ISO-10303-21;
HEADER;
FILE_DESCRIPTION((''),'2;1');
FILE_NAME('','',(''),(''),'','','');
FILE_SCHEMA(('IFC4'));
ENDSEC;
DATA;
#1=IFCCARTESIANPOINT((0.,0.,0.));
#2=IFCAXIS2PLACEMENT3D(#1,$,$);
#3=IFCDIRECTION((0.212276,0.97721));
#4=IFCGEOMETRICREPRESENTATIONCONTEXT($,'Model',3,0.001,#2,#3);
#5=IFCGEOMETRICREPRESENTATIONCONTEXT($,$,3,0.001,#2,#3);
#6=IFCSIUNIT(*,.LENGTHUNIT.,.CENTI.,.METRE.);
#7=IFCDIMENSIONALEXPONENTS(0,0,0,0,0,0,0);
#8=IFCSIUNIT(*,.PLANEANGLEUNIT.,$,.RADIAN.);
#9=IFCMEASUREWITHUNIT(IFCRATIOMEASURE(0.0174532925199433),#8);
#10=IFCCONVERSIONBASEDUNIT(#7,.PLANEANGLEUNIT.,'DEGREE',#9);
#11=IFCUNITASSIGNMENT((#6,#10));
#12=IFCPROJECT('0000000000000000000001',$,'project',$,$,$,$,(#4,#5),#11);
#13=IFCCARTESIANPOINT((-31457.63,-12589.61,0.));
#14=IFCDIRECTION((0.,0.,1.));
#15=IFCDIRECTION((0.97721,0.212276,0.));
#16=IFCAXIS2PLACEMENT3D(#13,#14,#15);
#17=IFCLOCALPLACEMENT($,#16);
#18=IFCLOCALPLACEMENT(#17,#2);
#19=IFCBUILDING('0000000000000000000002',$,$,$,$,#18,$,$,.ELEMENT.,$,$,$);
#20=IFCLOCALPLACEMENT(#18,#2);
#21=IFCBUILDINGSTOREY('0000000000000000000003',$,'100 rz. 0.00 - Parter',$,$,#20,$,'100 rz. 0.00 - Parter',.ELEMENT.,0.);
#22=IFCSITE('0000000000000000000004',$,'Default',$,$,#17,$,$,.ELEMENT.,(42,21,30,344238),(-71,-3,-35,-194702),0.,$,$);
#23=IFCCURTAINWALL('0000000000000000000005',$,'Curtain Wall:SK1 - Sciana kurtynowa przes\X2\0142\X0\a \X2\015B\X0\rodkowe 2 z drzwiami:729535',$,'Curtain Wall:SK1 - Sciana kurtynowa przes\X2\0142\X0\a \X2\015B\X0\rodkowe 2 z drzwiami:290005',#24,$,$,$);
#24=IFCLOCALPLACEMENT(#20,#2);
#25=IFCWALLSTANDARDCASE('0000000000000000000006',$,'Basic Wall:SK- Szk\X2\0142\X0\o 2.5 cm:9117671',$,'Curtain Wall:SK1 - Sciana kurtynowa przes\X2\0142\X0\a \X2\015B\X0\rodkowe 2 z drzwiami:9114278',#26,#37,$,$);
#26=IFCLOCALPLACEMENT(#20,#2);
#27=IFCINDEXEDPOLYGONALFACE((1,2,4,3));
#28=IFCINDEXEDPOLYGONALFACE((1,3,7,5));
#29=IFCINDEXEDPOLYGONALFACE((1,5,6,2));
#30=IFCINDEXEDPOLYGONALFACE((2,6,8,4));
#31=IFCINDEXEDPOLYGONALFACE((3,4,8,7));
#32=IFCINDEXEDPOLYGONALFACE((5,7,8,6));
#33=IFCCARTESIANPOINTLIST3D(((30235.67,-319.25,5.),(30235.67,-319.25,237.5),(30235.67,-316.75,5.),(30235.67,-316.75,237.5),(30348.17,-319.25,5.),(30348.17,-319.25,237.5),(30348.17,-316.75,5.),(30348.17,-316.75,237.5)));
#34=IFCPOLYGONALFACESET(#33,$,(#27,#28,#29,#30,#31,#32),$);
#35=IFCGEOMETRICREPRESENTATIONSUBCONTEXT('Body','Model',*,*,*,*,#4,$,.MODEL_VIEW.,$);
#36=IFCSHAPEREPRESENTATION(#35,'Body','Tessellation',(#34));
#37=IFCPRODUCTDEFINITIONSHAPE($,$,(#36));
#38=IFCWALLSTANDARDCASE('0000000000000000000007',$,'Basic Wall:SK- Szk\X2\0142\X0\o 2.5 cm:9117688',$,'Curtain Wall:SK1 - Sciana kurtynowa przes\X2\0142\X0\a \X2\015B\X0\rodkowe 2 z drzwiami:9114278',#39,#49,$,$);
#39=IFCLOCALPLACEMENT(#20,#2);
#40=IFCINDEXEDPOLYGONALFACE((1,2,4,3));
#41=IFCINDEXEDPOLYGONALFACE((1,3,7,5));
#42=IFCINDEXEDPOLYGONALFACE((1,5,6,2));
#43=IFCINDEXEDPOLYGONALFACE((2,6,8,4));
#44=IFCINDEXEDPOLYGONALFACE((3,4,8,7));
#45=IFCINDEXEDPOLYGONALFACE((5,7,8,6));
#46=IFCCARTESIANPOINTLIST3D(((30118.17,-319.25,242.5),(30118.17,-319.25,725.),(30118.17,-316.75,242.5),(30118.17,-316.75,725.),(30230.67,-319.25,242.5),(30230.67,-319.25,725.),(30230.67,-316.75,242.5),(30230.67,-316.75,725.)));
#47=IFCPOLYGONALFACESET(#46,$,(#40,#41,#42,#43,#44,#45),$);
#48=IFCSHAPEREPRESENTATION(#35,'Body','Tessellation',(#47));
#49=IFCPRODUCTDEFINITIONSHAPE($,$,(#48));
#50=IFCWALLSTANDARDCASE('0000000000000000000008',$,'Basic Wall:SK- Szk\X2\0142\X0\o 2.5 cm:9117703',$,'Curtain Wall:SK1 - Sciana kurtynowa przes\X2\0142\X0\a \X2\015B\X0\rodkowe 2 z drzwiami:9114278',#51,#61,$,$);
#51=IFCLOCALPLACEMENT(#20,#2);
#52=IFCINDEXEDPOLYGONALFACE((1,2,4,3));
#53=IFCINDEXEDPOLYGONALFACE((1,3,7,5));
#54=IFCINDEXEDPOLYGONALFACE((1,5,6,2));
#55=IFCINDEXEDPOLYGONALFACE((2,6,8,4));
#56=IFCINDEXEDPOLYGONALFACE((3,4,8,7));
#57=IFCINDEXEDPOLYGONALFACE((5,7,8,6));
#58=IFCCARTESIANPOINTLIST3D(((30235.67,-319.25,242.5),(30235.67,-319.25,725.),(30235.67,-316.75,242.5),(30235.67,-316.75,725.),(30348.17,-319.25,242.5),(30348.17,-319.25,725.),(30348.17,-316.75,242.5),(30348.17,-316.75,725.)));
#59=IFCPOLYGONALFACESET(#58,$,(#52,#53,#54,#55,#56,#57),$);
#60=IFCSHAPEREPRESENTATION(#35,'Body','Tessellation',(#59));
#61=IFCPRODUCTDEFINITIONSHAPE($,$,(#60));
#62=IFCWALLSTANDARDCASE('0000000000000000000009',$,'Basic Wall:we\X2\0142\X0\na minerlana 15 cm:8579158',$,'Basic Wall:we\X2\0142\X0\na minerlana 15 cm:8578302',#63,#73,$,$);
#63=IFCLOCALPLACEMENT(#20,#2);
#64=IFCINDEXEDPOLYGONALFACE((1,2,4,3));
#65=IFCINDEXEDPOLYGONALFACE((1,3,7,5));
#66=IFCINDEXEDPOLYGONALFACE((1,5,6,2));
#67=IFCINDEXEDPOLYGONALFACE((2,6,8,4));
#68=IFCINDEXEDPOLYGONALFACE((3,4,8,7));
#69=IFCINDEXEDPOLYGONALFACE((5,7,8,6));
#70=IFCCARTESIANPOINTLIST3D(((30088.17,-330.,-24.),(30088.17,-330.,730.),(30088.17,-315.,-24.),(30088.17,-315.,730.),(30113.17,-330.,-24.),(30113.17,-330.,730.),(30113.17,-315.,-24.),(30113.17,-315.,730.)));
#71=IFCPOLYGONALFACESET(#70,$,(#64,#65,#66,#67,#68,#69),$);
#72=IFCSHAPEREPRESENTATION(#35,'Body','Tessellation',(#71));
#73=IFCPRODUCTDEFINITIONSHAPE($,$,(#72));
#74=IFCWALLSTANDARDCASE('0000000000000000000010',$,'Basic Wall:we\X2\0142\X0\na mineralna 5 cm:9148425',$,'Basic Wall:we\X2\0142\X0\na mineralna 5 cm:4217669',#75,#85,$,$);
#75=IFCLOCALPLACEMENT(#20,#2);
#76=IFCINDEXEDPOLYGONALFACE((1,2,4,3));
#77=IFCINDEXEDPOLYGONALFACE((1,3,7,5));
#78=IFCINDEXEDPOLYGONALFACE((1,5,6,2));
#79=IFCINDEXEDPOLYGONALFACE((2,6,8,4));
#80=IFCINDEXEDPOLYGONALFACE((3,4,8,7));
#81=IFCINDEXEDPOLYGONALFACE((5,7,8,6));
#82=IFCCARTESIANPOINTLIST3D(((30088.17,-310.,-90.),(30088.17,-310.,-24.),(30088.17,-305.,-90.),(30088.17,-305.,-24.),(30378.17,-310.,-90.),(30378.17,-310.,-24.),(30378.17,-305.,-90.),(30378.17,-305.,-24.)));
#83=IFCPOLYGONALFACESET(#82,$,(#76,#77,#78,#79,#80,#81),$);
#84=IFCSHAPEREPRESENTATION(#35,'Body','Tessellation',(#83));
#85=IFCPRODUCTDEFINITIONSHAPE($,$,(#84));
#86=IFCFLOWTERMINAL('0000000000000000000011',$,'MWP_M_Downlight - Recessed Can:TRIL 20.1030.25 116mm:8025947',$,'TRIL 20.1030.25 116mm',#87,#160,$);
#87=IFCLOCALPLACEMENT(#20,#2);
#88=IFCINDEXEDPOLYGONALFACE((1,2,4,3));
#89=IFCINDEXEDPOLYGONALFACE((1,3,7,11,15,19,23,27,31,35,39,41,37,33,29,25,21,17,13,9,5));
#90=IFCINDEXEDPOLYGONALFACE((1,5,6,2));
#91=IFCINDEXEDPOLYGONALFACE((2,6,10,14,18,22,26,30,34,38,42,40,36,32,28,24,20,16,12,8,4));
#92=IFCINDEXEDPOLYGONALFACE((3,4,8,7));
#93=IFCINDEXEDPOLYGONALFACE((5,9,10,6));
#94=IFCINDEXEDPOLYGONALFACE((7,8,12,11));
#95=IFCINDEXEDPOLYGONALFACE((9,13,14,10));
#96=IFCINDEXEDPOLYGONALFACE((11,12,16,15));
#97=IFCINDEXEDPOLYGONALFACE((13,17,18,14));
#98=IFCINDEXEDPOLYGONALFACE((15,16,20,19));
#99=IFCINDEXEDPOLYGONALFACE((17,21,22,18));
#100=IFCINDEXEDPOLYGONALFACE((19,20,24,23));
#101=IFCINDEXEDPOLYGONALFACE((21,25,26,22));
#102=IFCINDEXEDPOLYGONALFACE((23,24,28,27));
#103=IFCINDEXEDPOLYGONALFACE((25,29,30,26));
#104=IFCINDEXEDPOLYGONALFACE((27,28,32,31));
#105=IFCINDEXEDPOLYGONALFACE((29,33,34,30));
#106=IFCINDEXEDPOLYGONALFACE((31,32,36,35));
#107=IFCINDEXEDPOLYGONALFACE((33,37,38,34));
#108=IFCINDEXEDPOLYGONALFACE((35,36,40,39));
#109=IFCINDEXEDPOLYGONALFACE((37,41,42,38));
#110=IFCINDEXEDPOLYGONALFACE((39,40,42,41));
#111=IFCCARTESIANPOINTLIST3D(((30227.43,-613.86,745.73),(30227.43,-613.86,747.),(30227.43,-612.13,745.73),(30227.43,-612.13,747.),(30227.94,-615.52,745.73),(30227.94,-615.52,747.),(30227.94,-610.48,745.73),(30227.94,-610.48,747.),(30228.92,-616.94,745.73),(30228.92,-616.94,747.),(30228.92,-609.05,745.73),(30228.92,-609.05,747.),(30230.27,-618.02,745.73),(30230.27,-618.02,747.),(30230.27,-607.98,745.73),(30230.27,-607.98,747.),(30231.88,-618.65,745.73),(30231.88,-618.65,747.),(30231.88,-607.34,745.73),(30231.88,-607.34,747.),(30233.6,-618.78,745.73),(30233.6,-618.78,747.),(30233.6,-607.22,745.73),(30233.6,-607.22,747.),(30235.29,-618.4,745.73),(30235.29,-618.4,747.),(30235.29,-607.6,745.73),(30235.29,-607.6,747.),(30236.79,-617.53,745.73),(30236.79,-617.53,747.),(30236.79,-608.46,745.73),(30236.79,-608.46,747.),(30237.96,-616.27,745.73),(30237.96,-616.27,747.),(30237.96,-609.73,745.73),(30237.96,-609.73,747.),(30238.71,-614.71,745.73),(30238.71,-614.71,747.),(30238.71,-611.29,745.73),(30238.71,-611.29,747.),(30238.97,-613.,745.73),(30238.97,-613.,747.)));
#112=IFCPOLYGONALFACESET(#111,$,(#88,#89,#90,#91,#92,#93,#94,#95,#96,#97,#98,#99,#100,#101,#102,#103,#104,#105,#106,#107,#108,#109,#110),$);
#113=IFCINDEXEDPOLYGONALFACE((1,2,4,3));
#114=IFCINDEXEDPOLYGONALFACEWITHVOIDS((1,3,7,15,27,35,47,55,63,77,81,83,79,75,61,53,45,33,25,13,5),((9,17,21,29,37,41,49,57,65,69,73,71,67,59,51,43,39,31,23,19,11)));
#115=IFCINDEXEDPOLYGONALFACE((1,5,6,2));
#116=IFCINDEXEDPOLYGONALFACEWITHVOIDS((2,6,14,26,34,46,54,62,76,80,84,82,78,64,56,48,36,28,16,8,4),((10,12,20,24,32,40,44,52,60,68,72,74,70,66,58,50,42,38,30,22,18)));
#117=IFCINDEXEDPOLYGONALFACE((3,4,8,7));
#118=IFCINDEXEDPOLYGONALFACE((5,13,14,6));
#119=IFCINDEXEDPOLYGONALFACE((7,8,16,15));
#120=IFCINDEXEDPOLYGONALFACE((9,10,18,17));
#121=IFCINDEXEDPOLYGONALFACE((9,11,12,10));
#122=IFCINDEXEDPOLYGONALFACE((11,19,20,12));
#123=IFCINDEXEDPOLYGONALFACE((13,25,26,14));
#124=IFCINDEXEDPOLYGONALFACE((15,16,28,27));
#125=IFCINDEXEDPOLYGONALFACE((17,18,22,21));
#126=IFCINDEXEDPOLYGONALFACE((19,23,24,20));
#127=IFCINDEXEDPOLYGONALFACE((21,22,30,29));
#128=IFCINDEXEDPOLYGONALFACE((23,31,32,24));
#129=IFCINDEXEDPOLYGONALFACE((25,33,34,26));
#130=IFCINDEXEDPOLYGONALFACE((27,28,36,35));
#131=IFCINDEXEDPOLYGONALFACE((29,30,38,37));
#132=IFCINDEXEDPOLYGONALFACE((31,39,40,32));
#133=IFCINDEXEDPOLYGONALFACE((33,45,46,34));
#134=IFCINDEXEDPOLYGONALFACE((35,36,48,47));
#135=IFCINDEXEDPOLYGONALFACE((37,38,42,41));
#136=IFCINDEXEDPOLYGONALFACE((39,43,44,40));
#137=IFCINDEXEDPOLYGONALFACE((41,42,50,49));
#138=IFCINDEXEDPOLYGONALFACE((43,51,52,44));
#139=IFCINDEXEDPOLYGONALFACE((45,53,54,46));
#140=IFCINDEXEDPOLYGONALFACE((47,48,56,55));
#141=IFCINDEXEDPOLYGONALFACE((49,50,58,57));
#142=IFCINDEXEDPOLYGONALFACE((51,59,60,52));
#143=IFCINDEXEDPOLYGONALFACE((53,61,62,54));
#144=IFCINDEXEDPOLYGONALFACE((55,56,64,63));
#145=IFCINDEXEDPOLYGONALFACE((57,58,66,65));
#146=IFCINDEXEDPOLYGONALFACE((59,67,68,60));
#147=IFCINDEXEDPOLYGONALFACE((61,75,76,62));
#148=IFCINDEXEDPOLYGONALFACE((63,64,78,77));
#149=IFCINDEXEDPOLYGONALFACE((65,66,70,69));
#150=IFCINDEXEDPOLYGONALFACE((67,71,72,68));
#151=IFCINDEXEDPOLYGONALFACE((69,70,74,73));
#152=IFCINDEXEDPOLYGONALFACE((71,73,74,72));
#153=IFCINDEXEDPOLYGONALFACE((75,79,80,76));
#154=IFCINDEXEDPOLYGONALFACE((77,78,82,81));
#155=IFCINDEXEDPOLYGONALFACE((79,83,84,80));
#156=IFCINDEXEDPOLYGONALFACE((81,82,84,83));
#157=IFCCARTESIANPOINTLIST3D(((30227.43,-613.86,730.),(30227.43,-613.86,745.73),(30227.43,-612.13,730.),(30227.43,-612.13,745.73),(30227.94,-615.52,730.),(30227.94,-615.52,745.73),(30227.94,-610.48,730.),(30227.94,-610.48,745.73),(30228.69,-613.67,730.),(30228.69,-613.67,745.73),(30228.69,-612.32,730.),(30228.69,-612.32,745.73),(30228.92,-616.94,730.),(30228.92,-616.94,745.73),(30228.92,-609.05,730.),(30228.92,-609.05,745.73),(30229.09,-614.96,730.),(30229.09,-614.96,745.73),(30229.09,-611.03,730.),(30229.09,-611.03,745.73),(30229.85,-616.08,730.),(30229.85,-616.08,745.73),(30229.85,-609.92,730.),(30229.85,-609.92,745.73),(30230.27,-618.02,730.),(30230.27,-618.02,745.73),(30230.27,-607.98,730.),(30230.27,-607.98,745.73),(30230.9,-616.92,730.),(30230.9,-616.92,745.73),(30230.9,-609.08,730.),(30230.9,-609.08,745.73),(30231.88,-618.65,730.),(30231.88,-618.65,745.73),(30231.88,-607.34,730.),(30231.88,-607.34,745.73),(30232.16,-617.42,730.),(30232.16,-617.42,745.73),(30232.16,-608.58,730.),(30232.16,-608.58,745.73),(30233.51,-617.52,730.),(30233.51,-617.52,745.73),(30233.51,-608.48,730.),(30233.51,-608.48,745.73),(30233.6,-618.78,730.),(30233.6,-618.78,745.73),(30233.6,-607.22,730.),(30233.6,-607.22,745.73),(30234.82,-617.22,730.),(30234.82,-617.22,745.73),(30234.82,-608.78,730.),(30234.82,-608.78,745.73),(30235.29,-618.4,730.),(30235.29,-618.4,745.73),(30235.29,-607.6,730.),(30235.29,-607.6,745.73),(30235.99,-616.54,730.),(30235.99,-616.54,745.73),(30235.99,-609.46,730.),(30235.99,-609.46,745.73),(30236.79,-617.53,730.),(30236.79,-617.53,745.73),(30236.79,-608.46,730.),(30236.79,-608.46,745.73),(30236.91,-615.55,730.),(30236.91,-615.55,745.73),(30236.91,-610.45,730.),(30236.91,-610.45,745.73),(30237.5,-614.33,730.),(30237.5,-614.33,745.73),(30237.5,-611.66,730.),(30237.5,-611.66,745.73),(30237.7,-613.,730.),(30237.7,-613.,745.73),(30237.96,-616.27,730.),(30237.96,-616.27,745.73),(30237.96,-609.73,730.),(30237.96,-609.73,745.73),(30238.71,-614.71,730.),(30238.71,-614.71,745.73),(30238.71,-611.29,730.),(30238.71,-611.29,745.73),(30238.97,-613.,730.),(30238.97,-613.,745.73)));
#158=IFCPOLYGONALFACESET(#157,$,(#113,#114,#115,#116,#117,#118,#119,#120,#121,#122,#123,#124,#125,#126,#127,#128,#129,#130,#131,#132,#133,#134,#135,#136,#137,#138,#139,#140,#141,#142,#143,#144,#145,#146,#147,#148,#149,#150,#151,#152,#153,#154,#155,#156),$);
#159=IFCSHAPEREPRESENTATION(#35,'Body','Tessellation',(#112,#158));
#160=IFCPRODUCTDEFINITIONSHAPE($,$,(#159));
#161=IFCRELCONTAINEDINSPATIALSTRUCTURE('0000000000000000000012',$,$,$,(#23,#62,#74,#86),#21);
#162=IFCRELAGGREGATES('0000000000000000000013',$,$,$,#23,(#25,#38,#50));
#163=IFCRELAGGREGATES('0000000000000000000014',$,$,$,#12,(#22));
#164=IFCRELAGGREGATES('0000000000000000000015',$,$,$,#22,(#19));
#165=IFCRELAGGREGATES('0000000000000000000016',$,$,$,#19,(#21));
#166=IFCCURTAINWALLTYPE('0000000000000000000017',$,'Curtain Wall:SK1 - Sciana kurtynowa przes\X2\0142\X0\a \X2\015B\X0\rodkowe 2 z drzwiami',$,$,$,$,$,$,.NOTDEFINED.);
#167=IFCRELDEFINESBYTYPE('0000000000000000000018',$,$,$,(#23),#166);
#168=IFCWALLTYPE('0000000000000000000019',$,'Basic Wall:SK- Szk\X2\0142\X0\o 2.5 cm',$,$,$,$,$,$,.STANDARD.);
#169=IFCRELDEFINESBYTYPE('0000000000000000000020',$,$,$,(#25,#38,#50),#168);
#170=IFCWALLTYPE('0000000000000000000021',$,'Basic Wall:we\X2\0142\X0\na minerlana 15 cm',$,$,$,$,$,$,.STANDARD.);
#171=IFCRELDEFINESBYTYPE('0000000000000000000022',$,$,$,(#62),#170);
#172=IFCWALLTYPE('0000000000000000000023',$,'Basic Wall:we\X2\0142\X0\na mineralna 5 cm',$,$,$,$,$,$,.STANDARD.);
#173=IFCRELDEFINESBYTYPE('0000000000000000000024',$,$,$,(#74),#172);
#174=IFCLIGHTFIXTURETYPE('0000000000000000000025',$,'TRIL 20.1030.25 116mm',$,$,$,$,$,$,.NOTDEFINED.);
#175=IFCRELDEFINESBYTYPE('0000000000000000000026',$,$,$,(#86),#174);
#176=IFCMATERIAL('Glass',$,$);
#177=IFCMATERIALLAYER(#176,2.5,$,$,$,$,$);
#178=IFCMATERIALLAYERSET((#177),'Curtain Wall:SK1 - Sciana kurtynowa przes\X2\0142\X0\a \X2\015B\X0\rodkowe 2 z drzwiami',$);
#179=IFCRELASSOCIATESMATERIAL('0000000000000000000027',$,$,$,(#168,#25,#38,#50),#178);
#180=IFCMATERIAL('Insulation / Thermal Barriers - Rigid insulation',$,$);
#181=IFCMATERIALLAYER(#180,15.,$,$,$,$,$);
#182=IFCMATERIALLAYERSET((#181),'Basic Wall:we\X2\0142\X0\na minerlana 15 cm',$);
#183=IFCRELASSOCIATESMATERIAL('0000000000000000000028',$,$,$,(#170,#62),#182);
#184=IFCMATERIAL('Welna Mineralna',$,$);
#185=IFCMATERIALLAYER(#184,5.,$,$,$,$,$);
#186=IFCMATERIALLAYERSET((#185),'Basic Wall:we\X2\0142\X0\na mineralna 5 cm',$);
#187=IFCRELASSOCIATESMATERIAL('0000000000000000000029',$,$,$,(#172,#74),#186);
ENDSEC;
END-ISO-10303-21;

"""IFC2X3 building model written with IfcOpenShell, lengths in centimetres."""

from ifc_helpers import new_model, entity, si_unit, converted_unit, direction, frame, frame_2d, origin, place, context, subcontext, project, spatial, polyline, rectangle, circle, hollow_circle, extrude, clip, bounded_halfspace, source, transform, mapped, material, layer, layer_set, layer_usage, type_object, type_shapes, element, aggregate, save


model = new_model("IFC2X3")

# Units and contexts
model_context = context("Model", 3, precision=0.001, world=origin(), true_north=direction((0.212276, 0.97721)))
context_of_model = context(None, 3, precision=0.001, world=origin(), true_north=direction((0.212276, 0.97721)))
body_context = subcontext(model_context, "Body", "Model", "MODEL_VIEW")
ifc_project = project(units=[si_unit("LENGTHUNIT", "METRE", prefix="CENTI"), converted_unit("PLANEANGLEUNIT", "DEGREE", entity("IfcRatioMeasure", 0.0174532925199433), si_unit("PLANEANGLEUNIT", "RADIAN"), dimensions=[0, 0, 0, 0, 0, 0, 0])], contexts=[model_context, context_of_model])

# Site, building, storey
site_placement = place(None, frame((-31457.63, -12589.61, 0.0), z_axis=(0.0, 0.0, 1.0), x_axis=(0.97721, 0.212276, 0.0)))
site = spatial("IfcSite", under=ifc_project, at=site_placement, Name="Default", CompositionType="ELEMENT", RefLatitude=(42, 21, 30, 344238), RefLongitude=(-71, -3, -35, -194702), RefElevation=0.0)
building_placement = place(site_placement, origin())
building = spatial("IfcBuilding", under=site, at=building_placement, CompositionType="ELEMENT")
storey_placement = place(building_placement, origin())
storey = spatial("IfcBuildingStorey", under=building, at=storey_placement, Name="100 rz. 0.00 - Parter", LongName="100 rz. 0.00 - Parter", CompositionType="ELEMENT", Elevation=0.0)

# Curtain wall
curtain_wall_type = type_object("IfcCurtainWallType", Name="Curtain Wall:SK1 - Sciana kurtynowa przesła środkowe 2 z drzwiami", PredefinedType="NOTDEFINED")
curtain_wall_placement = place(storey_placement, origin())
curtain_wall = element("IfcCurtainWall", 1, at=curtain_wall_placement, inside=storey, type_object=curtain_wall_type, Name="Curtain Wall:SK1 - Sciana kurtynowa przesła środkowe 2 z drzwiami:729535", ObjectType="Curtain Wall:SK1 - Sciana kurtynowa przesła środkowe 2 z drzwiami:290005")

# Walls
ifc_material_1 = material(Name="Glass")
ifc_layer_1 = layer(ifc_material_1, 2.5)
ifc_layer_set_1 = layer_set([ifc_layer_1], Name="Curtain Wall:SK1 - Sciana kurtynowa przesła środkowe 2 z drzwiami")
wall_type_1 = type_object("IfcWallType", Name="Basic Wall:SK- Szkło 2.5 cm", PredefinedType="STANDARD", material=ifc_layer_set_1)
ifc_layer_usage_1 = layer_usage(ifc_layer_set_1, "AXIS2", "NEGATIVE", 1.25)
wall_1_placement = place(storey_placement, frame((30235.67, -318.0, 5.0)))
wall_1 = element("IfcWallStandardCase", 2, at=wall_1_placement, type_object=wall_type_1, material=ifc_layer_usage_1, Name="Basic Wall:SK- Szkło 2.5 cm:9117671", ObjectType="Curtain Wall:SK1 - Sciana kurtynowa przesła środkowe 2 z drzwiami:9114278", context=body_context, shape_type="SweptSolid", body=[
    extrude(rectangle(XDim=112.5, YDim=2.5, at=frame_2d((56.25, 0.0), x_axis=(-1.0, 0.0))), origin(), (0.0, 0.0, 1.0), 232.5),
])
ifc_layer_usage_2 = layer_usage(ifc_layer_set_1, "AXIS2", "NEGATIVE", 1.25)
wall_2_placement = place(storey_placement, frame((30118.17, -318.0, 242.5)))
wall_2 = element("IfcWallStandardCase", 3, at=wall_2_placement, type_object=wall_type_1, material=ifc_layer_usage_2, Name="Basic Wall:SK- Szkło 2.5 cm:9117688", ObjectType="Curtain Wall:SK1 - Sciana kurtynowa przesła środkowe 2 z drzwiami:9114278", context=body_context, shape_type="SweptSolid", body=[
    extrude(rectangle(XDim=112.5, YDim=2.5, at=frame_2d((56.25, 0.0), x_axis=(-1.0, 0.0))), origin(), (0.0, 0.0, 1.0), 482.5),
])
ifc_layer_usage_3 = layer_usage(ifc_layer_set_1, "AXIS2", "NEGATIVE", 1.25)
wall_3_placement = place(storey_placement, frame((30235.67, -318.0, 242.5)))
wall_3 = element("IfcWallStandardCase", 4, at=wall_3_placement, type_object=wall_type_1, material=ifc_layer_usage_3, Name="Basic Wall:SK- Szkło 2.5 cm:9117703", ObjectType="Curtain Wall:SK1 - Sciana kurtynowa przesła środkowe 2 z drzwiami:9114278", context=body_context, shape_type="SweptSolid", body=[
    extrude(rectangle(XDim=112.5, YDim=2.5, at=frame_2d((56.25, 0.0), x_axis=(-1.0, 0.0))), origin(), (0.0, 0.0, 1.0), 482.5),
])
aggregate(curtain_wall, [wall_1, wall_2, wall_3])

# Walls
ifc_material_2 = material(Name="Insulation / Thermal Barriers - Rigid insulation")
ifc_layer_2 = layer(ifc_material_2, 15.0)
ifc_layer_set_2 = layer_set([ifc_layer_2], Name="Basic Wall:wełna minerlana 15 cm")
ifc_layer_usage_4 = layer_usage(ifc_layer_set_2, "AXIS2", "NEGATIVE", 7.5)
wall_type_2 = type_object("IfcWallType", Name="Basic Wall:wełna minerlana 15 cm", PredefinedType="STANDARD", material=ifc_layer_set_2)
wall_4_placement = place(storey_placement, frame((30088.17, -322.5, -24.0)))
element("IfcWallStandardCase", 5, at=wall_4_placement, inside=storey, type_object=wall_type_2, material=ifc_layer_usage_4, Name="Basic Wall:wełna minerlana 15 cm:8579158", ObjectType="Basic Wall:wełna minerlana 15 cm:8578302", context=body_context, shape_type="SweptSolid", body=[
    extrude(rectangle(XDim=25.0, YDim=15.0, at=frame_2d((12.5, 0.0), x_axis=(-1.0, 0.0))), origin(), (0.0, 0.0, 1.0), 754.0),
])
ifc_material_3 = material(Name="Welna Mineralna")
ifc_layer_3 = layer(ifc_material_3, 5.0)
ifc_layer_set_3 = layer_set([ifc_layer_3], Name="Basic Wall:wełna mineralna 5 cm")
ifc_layer_usage_5 = layer_usage(ifc_layer_set_3, "AXIS2", "NEGATIVE", 2.5)
wall_type_3 = type_object("IfcWallType", Name="Basic Wall:wełna mineralna 5 cm", PredefinedType="STANDARD", material=ifc_layer_set_3)
wall_5_placement = place(storey_placement, frame((30088.17, -307.5, -90.0)))
element("IfcWallStandardCase", 6, at=wall_5_placement, inside=storey, type_object=wall_type_3, material=ifc_layer_usage_5, Name="Basic Wall:wełna mineralna 5 cm:9148425", ObjectType="Basic Wall:wełna mineralna 5 cm:4217669", context=body_context, shape_type="Clipping", body=[
    clip(extrude(rectangle(XDim=290.0, YDim=5.0, at=frame_2d((145.0, 0.0), x_axis=(-1.0, 0.0))), origin(), (0.0, 0.0, 1.0), 66.0), bounded_halfspace(frame((290.0, -2.5, 0.0), z_axis=(0.0, 0.0, 1.0), x_axis=(0.0, -1.0, 0.0)), True, frame((290.0, -2.5, 0.0)), polyline([(0.0, 0.0), (0.0, 5.0), (-25.0, 5.0), (-265.0, 5.0), (-290.0, 5.0), (-290.0, 0.0), (0.0, 0.0)]))),
])

# Flow terminal
light_fixture_type_1 = type_object("IfcLightFixtureType", Name="TRIL 20.1030.25 116mm", PredefinedType="NOTDEFINED")
shared_shape_1 = source(origin(), body_context, "Body", "SweptSolid", [
    extrude(circle(Radius=5.8, at=frame_2d((0.0, 0.0), x_axis=(1.0, 0.0))), frame((5.96, 5.81, 15.73)), (0.0, 0.0, 1.0), 1.27),
    extrude(hollow_circle(Radius=5.8, WallThickness=1.27, at=frame_2d((0.0, 0.0), x_axis=(1.0, 0.0))), frame((5.96, 5.81, 0.0)), (0.0, 0.0, 1.0), 15.73),
])
type_shapes(light_fixture_type_1, [shared_shape_1])
for number, where, name in (
    (7, (30227.21, -618.81, 730.0), "MWP_M_Downlight - Recessed Can:TRIL 20.1030.25 116mm:8025947"),
):
    element("IfcFlowTerminal", number, at=place(storey_placement, frame(where)), inside=storey, type_object=light_fixture_type_1, Name=name, ObjectType="TRIL 20.1030.25 116mm", context=body_context, shape_type="MappedRepresentation", body=[
        mapped(shared_shape_1, transform((0.0, 0.0, 0.0), scale=1.0)),
    ])

save(model, "model.ifc")
